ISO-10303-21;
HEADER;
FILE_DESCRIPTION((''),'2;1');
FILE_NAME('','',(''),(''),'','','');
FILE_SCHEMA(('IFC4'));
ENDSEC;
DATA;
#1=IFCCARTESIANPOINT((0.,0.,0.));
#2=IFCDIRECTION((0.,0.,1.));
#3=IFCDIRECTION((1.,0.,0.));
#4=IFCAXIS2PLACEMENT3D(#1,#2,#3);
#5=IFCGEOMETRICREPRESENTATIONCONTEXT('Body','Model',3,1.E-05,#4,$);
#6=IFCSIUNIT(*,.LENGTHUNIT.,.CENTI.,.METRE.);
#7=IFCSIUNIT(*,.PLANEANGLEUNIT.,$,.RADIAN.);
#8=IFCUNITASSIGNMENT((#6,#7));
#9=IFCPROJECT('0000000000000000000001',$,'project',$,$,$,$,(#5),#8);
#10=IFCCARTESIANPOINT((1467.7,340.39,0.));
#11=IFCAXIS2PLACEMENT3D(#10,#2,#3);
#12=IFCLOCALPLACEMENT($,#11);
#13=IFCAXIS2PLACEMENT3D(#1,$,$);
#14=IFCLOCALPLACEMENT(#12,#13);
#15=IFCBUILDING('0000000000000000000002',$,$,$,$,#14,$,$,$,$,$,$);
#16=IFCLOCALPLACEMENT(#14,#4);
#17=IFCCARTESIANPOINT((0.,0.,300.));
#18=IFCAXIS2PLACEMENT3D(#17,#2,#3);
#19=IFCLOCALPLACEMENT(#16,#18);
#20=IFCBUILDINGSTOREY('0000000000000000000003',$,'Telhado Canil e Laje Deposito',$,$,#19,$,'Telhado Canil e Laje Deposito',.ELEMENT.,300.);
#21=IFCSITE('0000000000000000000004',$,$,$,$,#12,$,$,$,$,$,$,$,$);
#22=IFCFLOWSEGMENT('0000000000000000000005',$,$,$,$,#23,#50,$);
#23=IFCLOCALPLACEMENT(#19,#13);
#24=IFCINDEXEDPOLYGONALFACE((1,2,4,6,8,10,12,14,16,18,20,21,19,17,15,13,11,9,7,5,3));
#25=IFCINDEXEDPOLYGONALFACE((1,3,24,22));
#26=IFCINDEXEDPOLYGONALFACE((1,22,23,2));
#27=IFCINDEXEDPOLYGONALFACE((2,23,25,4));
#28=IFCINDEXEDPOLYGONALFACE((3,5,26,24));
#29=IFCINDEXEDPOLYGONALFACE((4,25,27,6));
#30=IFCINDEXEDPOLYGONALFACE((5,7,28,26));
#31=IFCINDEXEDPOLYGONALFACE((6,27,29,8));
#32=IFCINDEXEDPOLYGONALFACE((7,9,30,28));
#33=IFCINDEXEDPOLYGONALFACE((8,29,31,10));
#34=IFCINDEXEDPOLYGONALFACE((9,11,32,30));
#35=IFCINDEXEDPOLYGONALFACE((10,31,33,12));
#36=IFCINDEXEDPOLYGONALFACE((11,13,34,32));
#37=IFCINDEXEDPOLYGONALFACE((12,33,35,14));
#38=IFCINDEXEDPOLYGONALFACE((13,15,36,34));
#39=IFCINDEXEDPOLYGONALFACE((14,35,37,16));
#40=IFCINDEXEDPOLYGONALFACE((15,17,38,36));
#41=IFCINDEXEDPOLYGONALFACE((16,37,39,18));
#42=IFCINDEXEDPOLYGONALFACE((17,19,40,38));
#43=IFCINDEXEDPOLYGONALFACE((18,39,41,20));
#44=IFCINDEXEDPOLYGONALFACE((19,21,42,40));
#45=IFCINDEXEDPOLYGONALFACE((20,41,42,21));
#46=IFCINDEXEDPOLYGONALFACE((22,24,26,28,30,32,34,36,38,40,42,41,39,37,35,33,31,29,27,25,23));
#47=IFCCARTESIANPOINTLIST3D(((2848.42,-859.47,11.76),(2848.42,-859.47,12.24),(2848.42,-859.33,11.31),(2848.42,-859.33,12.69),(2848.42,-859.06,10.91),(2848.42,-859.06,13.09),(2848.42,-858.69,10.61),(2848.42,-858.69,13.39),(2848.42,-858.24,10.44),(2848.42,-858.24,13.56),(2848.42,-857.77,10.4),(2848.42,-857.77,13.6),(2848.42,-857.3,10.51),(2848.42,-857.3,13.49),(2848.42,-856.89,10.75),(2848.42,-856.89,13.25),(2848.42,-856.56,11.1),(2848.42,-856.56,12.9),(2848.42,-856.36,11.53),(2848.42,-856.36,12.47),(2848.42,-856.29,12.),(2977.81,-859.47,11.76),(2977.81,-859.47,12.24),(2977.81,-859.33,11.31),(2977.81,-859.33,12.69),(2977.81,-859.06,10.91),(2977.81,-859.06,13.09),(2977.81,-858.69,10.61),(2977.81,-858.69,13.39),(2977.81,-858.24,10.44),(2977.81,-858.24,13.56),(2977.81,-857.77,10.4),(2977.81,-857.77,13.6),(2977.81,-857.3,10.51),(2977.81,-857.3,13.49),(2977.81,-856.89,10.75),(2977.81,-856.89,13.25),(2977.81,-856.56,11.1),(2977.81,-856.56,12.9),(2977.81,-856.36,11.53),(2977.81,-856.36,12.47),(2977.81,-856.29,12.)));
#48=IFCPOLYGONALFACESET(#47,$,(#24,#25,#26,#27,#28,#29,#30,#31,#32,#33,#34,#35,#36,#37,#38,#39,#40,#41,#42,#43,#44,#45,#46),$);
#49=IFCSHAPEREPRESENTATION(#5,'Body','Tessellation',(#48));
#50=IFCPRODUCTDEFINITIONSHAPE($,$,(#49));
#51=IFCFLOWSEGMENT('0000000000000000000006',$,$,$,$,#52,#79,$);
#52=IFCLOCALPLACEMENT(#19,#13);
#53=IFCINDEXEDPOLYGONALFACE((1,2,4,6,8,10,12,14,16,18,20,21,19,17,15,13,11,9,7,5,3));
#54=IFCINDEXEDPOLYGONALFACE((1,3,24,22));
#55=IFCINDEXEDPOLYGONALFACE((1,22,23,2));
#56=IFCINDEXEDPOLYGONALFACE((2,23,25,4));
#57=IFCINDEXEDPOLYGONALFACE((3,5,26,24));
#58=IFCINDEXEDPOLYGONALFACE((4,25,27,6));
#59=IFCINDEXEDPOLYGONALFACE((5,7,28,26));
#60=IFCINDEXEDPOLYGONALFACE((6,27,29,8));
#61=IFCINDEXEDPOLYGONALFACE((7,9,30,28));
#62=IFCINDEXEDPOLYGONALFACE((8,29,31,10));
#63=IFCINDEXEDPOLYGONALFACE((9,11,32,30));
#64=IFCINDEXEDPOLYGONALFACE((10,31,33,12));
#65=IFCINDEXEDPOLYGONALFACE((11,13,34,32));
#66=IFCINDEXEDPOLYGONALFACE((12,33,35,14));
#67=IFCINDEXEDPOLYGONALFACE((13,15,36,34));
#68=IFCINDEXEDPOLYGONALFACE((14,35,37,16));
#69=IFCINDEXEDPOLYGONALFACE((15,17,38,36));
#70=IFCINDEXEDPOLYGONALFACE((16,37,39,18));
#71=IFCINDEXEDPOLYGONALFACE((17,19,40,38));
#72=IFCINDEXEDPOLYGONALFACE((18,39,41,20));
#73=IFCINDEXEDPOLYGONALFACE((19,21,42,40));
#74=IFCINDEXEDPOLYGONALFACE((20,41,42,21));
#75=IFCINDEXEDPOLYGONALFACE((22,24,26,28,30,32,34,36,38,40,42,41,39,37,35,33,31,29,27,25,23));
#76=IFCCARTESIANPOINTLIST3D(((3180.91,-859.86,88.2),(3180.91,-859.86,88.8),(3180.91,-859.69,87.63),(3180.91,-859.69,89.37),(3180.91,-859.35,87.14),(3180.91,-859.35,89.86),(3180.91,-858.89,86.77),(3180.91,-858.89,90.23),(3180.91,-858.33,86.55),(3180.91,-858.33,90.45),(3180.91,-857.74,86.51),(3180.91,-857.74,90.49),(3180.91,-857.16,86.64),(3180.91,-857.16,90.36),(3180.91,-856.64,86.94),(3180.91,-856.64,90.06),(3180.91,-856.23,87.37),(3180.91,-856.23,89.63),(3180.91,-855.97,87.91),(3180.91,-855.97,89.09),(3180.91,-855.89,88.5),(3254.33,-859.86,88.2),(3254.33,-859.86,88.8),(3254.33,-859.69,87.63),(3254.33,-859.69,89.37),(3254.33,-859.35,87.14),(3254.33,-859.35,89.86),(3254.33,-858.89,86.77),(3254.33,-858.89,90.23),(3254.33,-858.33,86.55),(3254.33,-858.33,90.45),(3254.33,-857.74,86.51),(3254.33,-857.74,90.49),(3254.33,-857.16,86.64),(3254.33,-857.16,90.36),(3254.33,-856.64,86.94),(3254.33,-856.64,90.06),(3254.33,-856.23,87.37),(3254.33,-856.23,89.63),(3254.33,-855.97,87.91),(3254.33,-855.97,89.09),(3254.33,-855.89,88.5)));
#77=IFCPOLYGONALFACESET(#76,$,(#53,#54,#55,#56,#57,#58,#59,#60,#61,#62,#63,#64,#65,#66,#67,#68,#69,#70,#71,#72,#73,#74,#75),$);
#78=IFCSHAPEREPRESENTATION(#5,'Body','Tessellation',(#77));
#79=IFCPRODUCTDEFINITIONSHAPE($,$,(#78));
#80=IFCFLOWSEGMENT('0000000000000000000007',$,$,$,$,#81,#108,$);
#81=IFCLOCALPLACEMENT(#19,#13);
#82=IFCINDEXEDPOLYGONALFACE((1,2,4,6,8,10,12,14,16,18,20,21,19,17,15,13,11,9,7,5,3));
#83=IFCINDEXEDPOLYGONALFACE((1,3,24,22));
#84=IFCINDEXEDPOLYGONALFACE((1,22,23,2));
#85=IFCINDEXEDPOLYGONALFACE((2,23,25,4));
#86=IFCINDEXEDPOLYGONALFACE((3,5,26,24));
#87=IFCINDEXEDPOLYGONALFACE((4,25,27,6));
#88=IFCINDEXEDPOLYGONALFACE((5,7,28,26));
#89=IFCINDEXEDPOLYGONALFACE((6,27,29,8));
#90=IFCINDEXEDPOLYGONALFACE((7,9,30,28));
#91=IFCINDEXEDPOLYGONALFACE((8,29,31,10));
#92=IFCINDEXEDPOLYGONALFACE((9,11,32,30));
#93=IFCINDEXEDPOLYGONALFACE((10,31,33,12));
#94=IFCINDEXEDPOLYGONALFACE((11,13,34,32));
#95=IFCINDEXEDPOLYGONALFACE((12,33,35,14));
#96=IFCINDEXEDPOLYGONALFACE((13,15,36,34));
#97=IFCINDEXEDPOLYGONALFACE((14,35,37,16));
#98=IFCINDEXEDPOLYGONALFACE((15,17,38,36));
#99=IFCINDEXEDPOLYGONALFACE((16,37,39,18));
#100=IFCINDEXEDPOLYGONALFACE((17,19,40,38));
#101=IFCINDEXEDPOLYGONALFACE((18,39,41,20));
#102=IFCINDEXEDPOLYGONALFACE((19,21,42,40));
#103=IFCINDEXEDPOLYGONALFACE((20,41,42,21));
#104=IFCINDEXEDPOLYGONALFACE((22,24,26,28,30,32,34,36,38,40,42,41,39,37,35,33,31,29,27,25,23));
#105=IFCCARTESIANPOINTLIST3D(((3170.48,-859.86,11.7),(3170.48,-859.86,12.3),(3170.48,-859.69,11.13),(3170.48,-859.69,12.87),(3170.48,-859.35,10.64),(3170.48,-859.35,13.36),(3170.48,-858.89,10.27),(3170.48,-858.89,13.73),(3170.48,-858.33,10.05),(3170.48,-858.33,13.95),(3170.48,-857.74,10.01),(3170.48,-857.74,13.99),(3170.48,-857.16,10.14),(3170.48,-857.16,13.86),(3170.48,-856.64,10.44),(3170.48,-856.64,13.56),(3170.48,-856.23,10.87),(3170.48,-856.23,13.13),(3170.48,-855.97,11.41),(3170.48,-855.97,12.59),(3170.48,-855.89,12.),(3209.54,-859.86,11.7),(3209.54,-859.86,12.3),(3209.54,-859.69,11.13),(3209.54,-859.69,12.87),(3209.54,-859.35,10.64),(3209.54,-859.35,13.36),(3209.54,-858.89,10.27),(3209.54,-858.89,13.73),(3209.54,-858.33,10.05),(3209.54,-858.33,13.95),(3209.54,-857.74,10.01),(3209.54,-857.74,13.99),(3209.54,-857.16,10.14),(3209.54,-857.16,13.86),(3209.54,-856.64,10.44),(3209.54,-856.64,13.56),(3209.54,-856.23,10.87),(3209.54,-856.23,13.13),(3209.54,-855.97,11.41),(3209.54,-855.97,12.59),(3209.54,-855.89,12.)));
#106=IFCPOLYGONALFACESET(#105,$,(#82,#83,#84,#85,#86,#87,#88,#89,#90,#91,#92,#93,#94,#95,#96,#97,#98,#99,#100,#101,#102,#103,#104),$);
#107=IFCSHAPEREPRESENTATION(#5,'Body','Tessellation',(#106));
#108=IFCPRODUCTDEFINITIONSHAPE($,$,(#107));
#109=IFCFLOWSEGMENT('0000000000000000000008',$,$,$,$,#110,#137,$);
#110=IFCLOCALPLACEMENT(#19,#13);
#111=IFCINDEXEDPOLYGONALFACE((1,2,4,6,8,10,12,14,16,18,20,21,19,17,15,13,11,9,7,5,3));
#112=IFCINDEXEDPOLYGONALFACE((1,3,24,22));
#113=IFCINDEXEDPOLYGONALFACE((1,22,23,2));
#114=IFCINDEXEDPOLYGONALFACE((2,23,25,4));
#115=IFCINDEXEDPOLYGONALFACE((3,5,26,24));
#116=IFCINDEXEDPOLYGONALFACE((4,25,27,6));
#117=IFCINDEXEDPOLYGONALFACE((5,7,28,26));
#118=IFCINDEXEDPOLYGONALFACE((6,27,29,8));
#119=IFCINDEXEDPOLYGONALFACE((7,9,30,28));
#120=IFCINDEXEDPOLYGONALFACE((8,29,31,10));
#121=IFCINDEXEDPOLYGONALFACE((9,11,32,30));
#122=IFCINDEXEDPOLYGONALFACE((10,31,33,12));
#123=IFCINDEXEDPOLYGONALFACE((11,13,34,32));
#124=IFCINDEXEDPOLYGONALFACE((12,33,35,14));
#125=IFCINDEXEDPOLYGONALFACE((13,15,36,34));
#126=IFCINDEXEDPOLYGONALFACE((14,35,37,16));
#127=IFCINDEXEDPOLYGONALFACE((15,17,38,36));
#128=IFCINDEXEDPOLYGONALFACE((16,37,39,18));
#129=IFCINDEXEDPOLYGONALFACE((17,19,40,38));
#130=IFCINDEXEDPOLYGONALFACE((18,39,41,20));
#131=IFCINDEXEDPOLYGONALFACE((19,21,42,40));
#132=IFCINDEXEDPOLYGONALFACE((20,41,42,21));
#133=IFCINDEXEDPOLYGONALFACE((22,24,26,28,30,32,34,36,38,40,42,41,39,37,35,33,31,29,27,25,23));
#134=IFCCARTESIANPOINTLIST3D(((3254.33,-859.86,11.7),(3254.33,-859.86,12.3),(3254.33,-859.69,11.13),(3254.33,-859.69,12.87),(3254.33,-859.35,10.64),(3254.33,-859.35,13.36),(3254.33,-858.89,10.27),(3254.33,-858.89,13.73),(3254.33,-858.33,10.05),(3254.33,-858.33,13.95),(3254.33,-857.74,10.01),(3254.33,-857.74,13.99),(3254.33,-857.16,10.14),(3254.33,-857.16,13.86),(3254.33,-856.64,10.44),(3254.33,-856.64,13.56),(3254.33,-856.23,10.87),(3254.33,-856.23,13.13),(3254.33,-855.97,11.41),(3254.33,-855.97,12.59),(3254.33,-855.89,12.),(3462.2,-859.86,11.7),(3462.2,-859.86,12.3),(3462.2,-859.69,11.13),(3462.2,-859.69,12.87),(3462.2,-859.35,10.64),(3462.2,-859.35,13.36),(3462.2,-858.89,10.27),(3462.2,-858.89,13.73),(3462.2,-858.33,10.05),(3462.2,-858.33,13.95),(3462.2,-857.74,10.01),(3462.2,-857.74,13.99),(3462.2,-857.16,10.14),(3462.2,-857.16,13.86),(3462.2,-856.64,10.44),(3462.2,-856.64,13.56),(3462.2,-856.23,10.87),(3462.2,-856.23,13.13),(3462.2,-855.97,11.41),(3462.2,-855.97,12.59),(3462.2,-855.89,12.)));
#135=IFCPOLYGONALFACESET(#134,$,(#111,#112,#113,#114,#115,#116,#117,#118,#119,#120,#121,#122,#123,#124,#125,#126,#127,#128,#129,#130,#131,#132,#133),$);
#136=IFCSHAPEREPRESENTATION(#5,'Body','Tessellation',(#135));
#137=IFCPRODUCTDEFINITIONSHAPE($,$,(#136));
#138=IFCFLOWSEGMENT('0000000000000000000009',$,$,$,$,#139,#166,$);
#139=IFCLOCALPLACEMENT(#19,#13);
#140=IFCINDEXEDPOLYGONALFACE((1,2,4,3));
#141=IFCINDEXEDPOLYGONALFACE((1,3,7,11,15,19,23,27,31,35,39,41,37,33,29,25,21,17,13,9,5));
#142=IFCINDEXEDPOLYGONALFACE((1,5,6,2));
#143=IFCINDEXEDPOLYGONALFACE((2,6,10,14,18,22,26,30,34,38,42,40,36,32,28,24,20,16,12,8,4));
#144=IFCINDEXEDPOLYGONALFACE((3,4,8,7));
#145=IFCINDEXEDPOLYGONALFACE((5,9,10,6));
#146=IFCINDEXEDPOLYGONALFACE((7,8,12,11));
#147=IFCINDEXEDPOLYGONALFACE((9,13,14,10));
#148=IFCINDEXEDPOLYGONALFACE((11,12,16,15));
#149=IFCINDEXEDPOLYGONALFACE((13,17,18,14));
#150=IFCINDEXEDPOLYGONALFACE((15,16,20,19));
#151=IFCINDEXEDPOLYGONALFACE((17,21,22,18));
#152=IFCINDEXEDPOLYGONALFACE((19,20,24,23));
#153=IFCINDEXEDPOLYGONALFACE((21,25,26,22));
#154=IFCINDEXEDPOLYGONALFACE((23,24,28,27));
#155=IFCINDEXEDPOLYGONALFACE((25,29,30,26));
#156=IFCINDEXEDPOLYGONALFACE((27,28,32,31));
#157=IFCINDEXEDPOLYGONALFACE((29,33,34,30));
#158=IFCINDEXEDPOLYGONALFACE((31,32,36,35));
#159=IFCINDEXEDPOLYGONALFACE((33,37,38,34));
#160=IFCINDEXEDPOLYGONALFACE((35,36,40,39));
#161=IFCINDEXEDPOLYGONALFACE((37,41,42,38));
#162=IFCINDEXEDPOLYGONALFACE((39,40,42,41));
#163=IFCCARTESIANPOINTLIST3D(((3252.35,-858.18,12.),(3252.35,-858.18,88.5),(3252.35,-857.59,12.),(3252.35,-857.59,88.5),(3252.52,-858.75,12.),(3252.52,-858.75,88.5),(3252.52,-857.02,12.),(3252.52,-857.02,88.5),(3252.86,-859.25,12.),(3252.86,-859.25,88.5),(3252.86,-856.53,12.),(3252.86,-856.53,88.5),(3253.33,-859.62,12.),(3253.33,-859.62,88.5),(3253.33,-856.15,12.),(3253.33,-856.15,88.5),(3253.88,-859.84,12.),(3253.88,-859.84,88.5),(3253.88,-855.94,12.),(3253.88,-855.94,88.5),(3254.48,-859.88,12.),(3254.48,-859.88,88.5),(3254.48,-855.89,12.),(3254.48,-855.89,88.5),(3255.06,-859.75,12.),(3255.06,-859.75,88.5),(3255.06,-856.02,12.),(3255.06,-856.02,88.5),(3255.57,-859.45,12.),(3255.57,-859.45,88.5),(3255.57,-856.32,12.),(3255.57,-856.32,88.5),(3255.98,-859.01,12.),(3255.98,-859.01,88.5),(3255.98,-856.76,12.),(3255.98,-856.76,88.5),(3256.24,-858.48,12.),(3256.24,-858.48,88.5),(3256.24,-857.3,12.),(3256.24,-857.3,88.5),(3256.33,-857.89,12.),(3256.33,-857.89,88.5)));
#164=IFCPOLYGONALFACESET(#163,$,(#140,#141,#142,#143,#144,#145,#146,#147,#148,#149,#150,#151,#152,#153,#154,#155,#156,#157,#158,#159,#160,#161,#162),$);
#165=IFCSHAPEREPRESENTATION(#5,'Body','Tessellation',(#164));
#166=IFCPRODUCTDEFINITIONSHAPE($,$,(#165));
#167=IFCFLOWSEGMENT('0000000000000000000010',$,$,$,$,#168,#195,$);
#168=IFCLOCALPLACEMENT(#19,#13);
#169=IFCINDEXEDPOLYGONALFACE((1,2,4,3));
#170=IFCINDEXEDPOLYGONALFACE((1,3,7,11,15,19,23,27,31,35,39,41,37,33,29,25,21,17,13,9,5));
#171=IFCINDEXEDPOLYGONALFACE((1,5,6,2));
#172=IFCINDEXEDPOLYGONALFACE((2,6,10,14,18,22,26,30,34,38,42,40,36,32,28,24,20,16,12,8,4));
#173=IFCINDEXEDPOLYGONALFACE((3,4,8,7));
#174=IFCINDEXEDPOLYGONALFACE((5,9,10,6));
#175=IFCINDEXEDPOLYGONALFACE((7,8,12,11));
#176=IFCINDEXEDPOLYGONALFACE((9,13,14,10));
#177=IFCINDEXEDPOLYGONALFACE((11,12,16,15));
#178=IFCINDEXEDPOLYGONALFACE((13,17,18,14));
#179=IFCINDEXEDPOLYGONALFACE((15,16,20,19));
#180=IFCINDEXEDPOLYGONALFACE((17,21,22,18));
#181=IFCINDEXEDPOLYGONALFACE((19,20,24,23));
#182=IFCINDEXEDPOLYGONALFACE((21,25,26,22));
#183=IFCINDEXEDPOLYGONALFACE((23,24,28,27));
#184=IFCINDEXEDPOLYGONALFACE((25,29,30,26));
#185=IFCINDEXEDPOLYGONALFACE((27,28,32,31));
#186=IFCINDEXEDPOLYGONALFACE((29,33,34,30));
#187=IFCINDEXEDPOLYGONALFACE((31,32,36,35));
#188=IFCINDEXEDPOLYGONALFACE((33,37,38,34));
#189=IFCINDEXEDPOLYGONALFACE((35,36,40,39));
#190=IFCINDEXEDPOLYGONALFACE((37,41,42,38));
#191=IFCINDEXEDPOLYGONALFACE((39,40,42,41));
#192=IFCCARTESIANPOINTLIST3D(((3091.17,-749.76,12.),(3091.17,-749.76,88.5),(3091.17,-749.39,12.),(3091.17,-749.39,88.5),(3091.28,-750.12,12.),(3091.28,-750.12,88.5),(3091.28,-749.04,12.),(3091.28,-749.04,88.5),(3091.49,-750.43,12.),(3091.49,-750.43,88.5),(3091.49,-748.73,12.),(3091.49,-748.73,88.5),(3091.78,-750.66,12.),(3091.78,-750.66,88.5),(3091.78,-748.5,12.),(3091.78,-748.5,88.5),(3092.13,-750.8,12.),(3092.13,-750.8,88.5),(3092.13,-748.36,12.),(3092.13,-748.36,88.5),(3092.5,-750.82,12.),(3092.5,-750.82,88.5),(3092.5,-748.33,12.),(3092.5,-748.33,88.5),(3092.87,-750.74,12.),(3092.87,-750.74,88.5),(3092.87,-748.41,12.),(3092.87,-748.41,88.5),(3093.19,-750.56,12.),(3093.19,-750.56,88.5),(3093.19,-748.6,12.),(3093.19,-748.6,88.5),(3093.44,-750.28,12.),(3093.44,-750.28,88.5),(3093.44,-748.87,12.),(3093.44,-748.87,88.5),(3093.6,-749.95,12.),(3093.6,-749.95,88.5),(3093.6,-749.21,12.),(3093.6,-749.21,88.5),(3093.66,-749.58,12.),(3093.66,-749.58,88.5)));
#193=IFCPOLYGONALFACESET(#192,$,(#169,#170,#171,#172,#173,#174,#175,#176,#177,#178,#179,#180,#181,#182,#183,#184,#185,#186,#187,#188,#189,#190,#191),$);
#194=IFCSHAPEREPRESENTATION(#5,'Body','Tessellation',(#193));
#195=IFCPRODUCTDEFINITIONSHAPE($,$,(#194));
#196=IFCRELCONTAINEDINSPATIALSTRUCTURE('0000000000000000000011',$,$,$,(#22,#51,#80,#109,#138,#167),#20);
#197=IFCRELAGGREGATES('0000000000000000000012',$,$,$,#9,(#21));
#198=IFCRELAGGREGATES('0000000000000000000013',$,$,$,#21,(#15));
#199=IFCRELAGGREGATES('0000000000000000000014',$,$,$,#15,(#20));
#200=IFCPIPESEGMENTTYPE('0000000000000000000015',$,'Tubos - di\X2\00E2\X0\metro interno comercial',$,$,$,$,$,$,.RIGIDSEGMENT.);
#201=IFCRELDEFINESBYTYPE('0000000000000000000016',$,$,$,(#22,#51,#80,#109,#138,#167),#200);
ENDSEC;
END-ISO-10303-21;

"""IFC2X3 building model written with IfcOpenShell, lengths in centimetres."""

from ifc_helpers import new_model, si_unit, frame, origin, origin_with_axes, origin_2d_with_axis, place, context, project, spatial, circle, extrude, type_object, element, save


model = new_model("IFC2X3")

# Units and contexts
model_context = context("Model", 3, precision=1e-05, world=origin_with_axes(), identifier="Body")
ifc_project = project(units=[si_unit("LENGTHUNIT", "METRE", prefix="CENTI"), si_unit("PLANEANGLEUNIT", "RADIAN")], contexts=[model_context])

# Site, building, storey
site_placement = place(None, frame((1467.7, 340.39, 0.0), z_axis=(0.0, 0.0, 1.0), x_axis=(1.0, 0.0, 0.0)))
site = spatial("IfcSite", under=ifc_project, at=site_placement)
building_placement = place(site_placement, origin())
building = spatial("IfcBuilding", under=site, at=building_placement)
placement = place(building_placement, origin_with_axes())
storey_placement = place(placement, frame((0.0, 0.0, 300.0), z_axis=(0.0, 0.0, 1.0), x_axis=(1.0, 0.0, 0.0)))
storey = spatial("IfcBuildingStorey", under=building, at=storey_placement, Name="Telhado Canil e Laje Deposito", LongName="Telhado Canil e Laje Deposito", CompositionType="ELEMENT", Elevation=300.0)

# Flow segments
pipe_segment_type = type_object("IfcPipeSegmentType", Name="Tubos - diâmetro interno comercial", PredefinedType="RIGIDSEGMENT")
flow_segment_1_placement = place(storey_placement, frame((2913.11, -857.89, 13.6), z_axis=(0.0, 0.0, 1.0), x_axis=(1.0, 0.0, 0.0)))
element("IfcFlowSegment", 1, at=flow_segment_1_placement, inside=storey, type_object=pipe_segment_type, context=model_context, shape_type="SolidModel", body=[
    extrude(circle(Radius=1.6, at=origin_2d_with_axis()), frame((64.69, 0.0, -1.6), z_axis=(-1.0, 0.0, 0.0), x_axis=(0.0, 1.0, 0.0)), (0.0, 0.0, 1.0), 129.39),
])
flow_segment_2_placement = place(storey_placement, frame((3217.62, -857.89, 90.5), z_axis=(0.0, 0.0, 1.0), x_axis=(1.0, 0.0, 0.0)))
element("IfcFlowSegment", 2, at=flow_segment_2_placement, inside=storey, type_object=pipe_segment_type, context=model_context, shape_type="SolidModel", body=[
    extrude(circle(Radius=2.0, at=origin_2d_with_axis()), frame((-36.71, 0.0, -2.0), z_axis=(1.0, 0.0, 0.0), x_axis=(0.0, 1.0, 0.0)), (0.0, 0.0, 1.0), 73.42),
])
flow_segment_3_placement = place(storey_placement, frame((3190.01, -857.89, 14.0), z_axis=(0.0, 0.0, 1.0), x_axis=(1.0, 0.0, 0.0)))
element("IfcFlowSegment", 3, at=flow_segment_3_placement, inside=storey, type_object=pipe_segment_type, context=model_context, shape_type="SolidModel", body=[
    extrude(circle(Radius=2.0, at=origin_2d_with_axis()), frame((-19.53, 0.0, -2.0), z_axis=(1.0, 0.0, 0.0), x_axis=(0.0, 1.0, 0.0)), (0.0, 0.0, 1.0), 39.06),
])
flow_segment_4_placement = place(storey_placement, frame((3358.26, -857.89, 14.0), z_axis=(0.0, 0.0, 1.0), x_axis=(1.0, 0.0, 0.0)))
element("IfcFlowSegment", 4, at=flow_segment_4_placement, inside=storey, type_object=pipe_segment_type, context=model_context, shape_type="SolidModel", body=[
    extrude(circle(Radius=2.0, at=origin_2d_with_axis()), frame((-103.94, 0.0, -2.0), z_axis=(1.0, 0.0, 0.0), x_axis=(0.0, 1.0, 0.0)), (0.0, 0.0, 1.0), 207.87),
])
flow_segment_5_placement = place(storey_placement, frame((3254.33, -857.89, 88.5), z_axis=(0.0, 0.0, 1.0), x_axis=(1.0, 0.0, 0.0)))
element("IfcFlowSegment", 5, at=flow_segment_5_placement, inside=storey, type_object=pipe_segment_type, context=model_context, shape_type="SolidModel", body=[
    extrude(circle(Radius=2.0, at=origin_2d_with_axis()), frame((0.0, 0.0, 0.0), z_axis=(0.0, 0.0, -1.0), x_axis=(1.0, 0.0, 0.0)), (0.0, 0.0, 1.0), 76.5),
])
flow_segment_6_placement = place(storey_placement, frame((3092.41, -749.58, 88.5), z_axis=(0.0, 0.0, 1.0), x_axis=(1.0, 0.0, 0.0)))
element("IfcFlowSegment", 6, at=flow_segment_6_placement, inside=storey, type_object=pipe_segment_type, context=model_context, shape_type="SolidModel", body=[
    extrude(circle(Radius=1.25, at=origin_2d_with_axis()), frame((0.0, 0.0, -76.5), z_axis=(0.0, 0.0, 1.0), x_axis=(1.0, 0.0, 0.0)), (0.0, 0.0, 1.0), 76.5),
])

save(model, "model.ifc")
